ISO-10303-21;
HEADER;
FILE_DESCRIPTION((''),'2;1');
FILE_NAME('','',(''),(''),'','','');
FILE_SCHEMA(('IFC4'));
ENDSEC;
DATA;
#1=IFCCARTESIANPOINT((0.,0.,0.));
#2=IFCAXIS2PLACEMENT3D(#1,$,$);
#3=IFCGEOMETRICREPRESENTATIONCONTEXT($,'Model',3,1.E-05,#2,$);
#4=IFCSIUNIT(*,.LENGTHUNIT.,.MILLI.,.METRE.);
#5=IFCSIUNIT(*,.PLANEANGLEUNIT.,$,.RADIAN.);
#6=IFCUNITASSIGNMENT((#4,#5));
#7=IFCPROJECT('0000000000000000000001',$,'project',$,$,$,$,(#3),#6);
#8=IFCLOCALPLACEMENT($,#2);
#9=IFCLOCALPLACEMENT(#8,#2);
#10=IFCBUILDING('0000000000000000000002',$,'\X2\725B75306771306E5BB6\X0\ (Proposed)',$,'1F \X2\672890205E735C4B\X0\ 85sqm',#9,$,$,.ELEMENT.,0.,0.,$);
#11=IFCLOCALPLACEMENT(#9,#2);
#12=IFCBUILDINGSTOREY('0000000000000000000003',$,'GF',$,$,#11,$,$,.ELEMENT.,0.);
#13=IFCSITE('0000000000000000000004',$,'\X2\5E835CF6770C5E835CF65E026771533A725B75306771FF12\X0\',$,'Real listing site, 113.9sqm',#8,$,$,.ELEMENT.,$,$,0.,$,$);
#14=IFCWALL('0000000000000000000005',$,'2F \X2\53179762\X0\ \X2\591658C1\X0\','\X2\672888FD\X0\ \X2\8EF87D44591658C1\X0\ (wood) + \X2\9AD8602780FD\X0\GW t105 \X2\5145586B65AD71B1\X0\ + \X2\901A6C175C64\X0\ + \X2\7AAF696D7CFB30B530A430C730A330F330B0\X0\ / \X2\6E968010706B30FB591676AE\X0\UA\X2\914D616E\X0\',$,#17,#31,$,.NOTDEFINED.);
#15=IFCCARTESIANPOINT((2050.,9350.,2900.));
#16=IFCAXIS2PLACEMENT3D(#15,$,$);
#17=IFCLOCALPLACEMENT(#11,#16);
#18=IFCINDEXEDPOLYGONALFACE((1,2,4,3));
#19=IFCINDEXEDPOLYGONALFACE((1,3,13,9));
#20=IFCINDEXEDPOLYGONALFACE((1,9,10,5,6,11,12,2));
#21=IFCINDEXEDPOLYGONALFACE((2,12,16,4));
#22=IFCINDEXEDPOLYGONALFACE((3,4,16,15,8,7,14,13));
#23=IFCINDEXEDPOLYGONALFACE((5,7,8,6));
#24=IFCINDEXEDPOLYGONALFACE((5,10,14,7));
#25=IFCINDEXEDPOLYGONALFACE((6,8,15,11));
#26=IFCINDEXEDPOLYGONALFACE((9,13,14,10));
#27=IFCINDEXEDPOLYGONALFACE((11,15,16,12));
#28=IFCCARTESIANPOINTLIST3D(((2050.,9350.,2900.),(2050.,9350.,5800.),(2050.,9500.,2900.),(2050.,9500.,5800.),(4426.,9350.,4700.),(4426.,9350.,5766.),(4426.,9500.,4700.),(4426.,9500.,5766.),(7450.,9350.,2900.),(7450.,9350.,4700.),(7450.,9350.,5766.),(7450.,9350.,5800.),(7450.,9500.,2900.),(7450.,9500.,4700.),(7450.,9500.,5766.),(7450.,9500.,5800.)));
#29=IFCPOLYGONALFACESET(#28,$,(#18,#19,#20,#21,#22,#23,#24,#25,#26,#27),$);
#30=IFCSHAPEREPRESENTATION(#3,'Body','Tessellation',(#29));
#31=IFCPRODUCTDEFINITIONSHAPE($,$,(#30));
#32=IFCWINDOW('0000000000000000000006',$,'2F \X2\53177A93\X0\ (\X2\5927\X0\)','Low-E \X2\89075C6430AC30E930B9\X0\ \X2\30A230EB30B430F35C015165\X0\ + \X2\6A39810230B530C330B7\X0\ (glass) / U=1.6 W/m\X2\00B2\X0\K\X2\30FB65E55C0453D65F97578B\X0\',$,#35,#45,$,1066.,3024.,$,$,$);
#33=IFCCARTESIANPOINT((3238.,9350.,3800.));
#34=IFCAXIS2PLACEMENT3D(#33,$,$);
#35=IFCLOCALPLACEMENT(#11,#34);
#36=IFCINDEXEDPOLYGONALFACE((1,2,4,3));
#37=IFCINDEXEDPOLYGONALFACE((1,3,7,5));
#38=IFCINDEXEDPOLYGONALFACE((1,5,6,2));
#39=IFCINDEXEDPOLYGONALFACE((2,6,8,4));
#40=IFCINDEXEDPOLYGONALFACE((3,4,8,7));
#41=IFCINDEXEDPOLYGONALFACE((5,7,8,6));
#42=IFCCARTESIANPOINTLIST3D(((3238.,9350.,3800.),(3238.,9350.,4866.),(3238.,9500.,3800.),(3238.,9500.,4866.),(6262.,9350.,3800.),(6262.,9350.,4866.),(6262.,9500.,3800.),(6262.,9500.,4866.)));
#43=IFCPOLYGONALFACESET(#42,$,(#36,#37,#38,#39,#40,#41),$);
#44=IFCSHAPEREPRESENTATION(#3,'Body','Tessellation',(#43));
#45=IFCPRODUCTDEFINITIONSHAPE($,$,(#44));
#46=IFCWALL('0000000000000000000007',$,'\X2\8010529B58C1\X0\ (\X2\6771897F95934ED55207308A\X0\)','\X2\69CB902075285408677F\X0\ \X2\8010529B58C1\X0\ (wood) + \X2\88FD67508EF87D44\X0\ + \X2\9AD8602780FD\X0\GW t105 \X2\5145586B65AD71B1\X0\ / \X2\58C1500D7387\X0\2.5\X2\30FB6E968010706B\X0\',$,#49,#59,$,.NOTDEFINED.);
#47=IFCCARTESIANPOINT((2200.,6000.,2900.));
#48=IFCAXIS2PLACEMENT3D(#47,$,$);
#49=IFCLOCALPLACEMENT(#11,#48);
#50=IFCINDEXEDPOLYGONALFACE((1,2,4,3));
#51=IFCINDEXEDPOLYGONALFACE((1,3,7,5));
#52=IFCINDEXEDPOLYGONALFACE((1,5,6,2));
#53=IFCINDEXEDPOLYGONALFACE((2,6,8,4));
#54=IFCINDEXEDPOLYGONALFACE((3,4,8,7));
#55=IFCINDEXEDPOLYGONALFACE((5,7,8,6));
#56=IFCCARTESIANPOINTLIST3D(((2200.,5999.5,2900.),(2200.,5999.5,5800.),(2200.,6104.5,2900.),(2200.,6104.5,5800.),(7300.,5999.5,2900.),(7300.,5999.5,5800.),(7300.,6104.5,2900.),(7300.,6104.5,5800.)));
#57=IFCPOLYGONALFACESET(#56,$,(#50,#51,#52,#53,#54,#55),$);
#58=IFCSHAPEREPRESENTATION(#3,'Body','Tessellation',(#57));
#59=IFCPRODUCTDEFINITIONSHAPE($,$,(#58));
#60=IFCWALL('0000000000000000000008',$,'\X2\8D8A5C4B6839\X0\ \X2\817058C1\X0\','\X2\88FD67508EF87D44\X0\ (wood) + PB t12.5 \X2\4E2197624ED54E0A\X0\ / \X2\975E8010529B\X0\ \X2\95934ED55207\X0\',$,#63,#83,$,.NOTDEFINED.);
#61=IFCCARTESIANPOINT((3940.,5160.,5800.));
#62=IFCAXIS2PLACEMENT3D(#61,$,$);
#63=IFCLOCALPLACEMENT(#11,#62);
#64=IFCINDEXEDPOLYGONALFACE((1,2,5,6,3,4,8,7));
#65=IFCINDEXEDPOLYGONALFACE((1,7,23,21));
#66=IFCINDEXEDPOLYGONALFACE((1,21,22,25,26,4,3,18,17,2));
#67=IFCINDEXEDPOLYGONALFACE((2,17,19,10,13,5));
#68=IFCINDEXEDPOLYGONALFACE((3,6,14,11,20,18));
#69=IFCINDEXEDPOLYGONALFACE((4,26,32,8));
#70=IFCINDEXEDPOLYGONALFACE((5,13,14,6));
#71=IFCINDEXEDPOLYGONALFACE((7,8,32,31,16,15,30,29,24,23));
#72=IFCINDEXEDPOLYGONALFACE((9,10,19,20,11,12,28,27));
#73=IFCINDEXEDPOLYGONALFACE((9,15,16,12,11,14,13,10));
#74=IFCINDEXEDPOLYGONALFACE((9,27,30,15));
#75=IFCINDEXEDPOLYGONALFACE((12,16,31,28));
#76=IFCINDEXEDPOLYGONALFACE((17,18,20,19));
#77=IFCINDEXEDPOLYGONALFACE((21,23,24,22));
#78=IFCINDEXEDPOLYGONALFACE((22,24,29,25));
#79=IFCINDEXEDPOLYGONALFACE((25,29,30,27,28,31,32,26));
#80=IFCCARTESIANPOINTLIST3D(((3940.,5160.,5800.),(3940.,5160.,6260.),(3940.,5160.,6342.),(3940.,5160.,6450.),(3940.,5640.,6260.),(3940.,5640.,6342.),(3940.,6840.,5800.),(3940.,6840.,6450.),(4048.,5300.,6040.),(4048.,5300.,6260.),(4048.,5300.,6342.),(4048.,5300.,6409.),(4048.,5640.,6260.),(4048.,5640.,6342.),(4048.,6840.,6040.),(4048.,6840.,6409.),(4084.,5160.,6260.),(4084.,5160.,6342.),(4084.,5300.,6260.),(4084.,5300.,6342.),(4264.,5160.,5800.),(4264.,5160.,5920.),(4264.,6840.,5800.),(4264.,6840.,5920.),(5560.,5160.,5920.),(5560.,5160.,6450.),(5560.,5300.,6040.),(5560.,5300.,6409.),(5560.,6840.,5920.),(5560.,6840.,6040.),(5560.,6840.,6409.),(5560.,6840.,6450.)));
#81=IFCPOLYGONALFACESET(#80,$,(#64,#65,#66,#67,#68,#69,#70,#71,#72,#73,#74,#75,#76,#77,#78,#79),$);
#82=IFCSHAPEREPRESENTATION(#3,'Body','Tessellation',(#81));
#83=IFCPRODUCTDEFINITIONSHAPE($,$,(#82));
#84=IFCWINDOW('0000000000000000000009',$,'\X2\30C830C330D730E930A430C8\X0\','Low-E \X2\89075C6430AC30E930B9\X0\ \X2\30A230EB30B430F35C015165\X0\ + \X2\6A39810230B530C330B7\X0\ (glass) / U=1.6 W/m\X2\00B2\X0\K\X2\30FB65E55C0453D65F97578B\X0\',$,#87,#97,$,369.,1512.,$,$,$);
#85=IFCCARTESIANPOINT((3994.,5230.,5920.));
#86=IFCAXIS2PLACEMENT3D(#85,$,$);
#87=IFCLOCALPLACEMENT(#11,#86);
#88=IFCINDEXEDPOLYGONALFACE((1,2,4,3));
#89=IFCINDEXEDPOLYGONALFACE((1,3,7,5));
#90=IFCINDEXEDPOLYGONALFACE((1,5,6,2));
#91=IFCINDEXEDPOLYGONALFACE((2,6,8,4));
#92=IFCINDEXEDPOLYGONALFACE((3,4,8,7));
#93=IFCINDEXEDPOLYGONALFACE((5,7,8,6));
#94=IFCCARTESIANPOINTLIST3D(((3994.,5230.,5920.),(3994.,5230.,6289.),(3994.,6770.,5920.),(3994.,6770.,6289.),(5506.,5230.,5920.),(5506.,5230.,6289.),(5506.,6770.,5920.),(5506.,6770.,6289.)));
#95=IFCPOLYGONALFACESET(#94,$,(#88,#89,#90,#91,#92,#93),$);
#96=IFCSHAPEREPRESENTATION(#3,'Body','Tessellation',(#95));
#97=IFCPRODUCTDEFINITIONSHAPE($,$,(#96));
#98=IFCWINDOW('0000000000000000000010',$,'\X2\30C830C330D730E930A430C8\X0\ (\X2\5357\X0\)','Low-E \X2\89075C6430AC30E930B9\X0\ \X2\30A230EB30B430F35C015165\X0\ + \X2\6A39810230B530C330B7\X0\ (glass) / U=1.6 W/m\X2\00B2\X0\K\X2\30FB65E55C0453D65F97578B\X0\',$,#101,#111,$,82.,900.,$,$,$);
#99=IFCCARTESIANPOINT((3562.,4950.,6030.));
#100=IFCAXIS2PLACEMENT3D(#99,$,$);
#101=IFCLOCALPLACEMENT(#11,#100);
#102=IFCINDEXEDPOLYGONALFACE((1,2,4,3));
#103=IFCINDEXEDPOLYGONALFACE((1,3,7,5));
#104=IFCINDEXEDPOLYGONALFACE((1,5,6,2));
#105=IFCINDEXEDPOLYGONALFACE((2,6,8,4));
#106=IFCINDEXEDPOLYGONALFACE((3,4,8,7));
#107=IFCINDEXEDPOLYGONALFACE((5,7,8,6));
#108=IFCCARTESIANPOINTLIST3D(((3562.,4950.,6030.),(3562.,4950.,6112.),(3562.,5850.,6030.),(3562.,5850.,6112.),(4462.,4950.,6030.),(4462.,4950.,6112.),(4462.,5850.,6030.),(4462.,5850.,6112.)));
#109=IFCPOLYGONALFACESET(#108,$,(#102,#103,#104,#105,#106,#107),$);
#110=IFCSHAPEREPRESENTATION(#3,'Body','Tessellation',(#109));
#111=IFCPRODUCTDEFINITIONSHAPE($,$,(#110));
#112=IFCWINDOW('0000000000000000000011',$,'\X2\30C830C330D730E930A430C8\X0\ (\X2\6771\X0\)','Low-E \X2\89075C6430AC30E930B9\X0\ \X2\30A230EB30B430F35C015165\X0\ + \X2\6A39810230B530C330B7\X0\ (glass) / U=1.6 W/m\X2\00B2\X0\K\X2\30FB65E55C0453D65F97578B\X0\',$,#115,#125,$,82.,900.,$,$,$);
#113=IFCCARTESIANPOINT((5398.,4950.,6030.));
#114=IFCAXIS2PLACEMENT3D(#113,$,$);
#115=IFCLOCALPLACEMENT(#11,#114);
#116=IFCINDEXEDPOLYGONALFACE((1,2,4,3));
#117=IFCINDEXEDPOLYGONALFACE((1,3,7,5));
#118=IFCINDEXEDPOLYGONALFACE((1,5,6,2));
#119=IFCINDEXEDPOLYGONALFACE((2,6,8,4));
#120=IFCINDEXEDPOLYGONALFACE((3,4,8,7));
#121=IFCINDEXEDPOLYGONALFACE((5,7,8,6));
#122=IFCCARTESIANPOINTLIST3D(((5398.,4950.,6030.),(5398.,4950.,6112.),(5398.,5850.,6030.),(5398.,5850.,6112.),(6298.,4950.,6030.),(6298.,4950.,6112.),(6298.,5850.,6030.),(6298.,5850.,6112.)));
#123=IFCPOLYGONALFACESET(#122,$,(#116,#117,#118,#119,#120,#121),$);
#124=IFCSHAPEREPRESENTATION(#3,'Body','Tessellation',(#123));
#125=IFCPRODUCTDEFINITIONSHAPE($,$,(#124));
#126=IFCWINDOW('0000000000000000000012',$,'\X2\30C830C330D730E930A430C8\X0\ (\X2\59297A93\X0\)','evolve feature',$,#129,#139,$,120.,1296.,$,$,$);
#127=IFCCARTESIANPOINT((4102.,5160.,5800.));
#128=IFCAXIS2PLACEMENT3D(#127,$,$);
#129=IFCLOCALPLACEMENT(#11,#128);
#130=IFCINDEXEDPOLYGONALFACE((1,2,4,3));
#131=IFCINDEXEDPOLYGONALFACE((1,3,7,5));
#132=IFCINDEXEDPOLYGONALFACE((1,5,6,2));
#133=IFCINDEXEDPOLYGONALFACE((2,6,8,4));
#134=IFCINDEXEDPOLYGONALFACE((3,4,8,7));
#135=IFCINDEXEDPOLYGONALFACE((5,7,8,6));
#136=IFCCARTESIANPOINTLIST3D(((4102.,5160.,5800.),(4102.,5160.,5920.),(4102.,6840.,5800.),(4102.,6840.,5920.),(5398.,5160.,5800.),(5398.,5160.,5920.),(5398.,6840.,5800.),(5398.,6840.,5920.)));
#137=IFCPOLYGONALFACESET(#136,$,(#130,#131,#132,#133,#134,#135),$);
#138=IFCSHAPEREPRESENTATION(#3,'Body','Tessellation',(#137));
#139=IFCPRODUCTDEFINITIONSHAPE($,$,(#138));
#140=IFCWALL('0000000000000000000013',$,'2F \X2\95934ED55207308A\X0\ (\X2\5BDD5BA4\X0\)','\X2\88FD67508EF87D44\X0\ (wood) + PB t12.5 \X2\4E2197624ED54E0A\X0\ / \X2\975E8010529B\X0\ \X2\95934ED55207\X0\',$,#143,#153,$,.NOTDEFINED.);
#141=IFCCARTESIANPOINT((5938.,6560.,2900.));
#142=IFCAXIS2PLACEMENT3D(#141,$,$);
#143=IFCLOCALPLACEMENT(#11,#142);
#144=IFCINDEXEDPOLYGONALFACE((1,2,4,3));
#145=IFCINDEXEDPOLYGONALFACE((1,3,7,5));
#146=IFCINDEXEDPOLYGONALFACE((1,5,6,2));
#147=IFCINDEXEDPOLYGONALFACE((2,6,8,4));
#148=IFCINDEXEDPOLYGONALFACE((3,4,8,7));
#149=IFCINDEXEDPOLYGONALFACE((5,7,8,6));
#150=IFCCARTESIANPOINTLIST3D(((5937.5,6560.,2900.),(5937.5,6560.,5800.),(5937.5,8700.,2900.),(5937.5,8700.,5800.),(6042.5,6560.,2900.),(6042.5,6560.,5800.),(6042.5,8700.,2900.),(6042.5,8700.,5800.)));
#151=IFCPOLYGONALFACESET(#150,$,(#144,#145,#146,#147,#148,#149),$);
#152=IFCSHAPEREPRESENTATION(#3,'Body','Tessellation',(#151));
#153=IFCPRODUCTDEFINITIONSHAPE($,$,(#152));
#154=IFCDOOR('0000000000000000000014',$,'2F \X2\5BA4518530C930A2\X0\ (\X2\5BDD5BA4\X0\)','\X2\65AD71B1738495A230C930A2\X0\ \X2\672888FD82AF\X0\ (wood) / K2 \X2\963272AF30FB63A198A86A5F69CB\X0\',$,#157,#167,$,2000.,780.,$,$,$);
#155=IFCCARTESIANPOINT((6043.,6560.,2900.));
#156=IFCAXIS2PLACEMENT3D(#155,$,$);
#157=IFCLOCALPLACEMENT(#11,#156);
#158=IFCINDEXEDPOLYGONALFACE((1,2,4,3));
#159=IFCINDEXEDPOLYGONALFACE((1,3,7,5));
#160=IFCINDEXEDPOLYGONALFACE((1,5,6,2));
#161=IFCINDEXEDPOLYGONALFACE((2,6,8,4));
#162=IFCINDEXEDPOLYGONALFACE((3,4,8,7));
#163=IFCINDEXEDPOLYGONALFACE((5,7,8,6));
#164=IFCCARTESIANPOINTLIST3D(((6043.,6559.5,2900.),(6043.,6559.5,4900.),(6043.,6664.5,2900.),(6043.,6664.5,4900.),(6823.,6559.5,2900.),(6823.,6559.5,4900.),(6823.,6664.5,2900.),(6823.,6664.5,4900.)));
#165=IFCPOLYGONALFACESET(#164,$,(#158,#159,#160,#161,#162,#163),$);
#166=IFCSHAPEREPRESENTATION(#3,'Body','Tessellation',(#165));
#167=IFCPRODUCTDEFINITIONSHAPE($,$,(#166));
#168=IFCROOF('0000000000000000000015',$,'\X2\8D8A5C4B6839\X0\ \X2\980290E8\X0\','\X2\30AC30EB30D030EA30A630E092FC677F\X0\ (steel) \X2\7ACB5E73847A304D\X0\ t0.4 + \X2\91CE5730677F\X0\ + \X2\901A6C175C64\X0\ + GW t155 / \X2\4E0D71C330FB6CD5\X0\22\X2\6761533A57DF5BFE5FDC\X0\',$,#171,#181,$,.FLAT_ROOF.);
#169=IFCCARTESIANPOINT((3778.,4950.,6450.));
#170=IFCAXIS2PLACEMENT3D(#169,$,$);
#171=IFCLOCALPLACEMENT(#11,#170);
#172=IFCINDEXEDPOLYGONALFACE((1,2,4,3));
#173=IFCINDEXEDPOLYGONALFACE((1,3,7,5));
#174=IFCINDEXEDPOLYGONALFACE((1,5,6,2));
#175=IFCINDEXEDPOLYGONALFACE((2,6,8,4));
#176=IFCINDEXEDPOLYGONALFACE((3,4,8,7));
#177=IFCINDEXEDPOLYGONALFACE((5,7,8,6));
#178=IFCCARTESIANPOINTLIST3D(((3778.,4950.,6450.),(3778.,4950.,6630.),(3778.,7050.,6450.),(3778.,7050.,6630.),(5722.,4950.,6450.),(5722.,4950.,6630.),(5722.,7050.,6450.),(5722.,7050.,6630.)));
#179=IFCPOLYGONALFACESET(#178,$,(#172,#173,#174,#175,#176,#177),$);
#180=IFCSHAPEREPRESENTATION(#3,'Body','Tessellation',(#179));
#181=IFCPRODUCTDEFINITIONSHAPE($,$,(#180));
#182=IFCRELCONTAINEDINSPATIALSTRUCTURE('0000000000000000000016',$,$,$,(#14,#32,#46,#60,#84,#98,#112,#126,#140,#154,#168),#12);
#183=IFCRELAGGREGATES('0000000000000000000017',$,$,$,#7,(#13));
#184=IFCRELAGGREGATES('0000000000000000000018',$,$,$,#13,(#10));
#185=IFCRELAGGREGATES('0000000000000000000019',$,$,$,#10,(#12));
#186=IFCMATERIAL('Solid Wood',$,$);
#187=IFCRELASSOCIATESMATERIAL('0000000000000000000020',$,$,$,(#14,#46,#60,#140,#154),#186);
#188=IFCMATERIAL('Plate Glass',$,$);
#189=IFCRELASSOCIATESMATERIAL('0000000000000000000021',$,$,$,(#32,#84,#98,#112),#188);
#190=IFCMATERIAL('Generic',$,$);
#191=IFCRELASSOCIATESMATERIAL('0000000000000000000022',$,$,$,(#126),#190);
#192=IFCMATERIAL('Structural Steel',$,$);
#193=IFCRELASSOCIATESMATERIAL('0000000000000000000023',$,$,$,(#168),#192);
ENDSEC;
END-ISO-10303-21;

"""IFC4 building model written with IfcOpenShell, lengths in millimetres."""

from ifc_helpers import new_model, si_unit, frame, frame_2d, origin, place, context, project, spatial, rectangle, extrude, material, element, fill, save


model = new_model("IFC4")

# Units and contexts
model_context = context("Model", 3, precision=1e-05, world=origin())
ifc_project = project(units=[si_unit("LENGTHUNIT", "METRE", prefix="MILLI"), si_unit("PLANEANGLEUNIT", "RADIAN")], contexts=[model_context])

# Site, building, storey
site_placement = place(None, origin())
site = spatial("IfcSite", under=ifc_project, at=site_placement, Name="広島県広島市東区牛田東２", ObjectType="Real listing site, 113.9sqm", CompositionType="ELEMENT", RefElevation=0.0)
building_placement = place(site_placement, origin())
building = spatial("IfcBuilding", under=site, at=building_placement, Name="牛田東の家 (Proposed)", ObjectType="1F 木造平屋 85sqm", CompositionType="ELEMENT", ElevationOfRefHeight=0.0, ElevationOfTerrain=0.0)
storey_placement = place(building_placement, origin())
storey = spatial("IfcBuildingStorey", under=building, at=storey_placement, Name="GF", CompositionType="ELEMENT", Elevation=0.0)

# Wall, opening, window
ifc_material_1 = material(Name="Solid Wood")
wall_1_placement = place(storey_placement, frame((2050.0, 9350.0, 2900.0)))
wall_1 = element("IfcWall", 1, at=wall_1_placement, inside=storey, material=ifc_material_1, Name="2F 北面 外壁", Description="木製 軸組外壁 (wood) + 高性能GW t105 充填断熱 + 通気層 + 窯業系サイディング / 準耐火・外皮UA配慮", PredefinedType="NOTDEFINED", context=model_context, shape_type="SweptSolid", body=[
    extrude(rectangle(XDim=5400.0, YDim=150.0, at=frame_2d((2700.0, 75.0))), frame((2050.0, 9350.0, 2900.0)), (0.0, 0.0, 1.0), 2900.0),
])
opening_1_placement = place(storey_placement, frame((3238.0, 9350.0, 3800.0)))
opening_1 = element("IfcOpeningElement", 2, at=opening_1_placement, cuts=wall_1, PredefinedType="NOTDEFINED", context=model_context, shape_type="SweptSolid", body=[
    extrude(rectangle(XDim=3024.0, YDim=150.0, at=frame_2d((1512.0, 75.0))), frame((3238.0, 9350.0, 3800.0)), (0.0, 0.0, 1.0), 1066.0),
])
ifc_material_2 = material(Name="Plate Glass")
window_1_placement = place(storey_placement, frame((3238.0, 9350.0, 3800.0)))
window_1 = element("IfcWindow", 3, at=window_1_placement, inside=storey, material=ifc_material_2, Name="2F 北窓 (大)", Description="Low-E 複層ガラス アルゴン封入 + 樹脂サッシ (glass) / U=1.6 W/m²K・日射取得型", OverallHeight=1066.0, OverallWidth=3024.0, context=model_context, shape_type="SweptSolid", body=[
    extrude(rectangle(XDim=3024.0, YDim=150.0, at=frame_2d((1512.0, 75.0))), frame((3238.0, 9350.0, 3800.0)), (0.0, 0.0, 1.0), 1066.0),
])
fill(opening_1, window_1)

# Wall
wall_2_placement = place(storey_placement, frame((2200.0, 6000.0, 2900.0)))
element("IfcWall", 4, at=wall_2_placement, inside=storey, material=ifc_material_1, Name="耐力壁 (東西間仕切り)", Description="構造用合板 耐力壁 (wood) + 製材軸組 + 高性能GW t105 充填断熱 / 壁倍率2.5・準耐火", PredefinedType="NOTDEFINED", context=model_context, shape_type="SweptSolid", body=[
    extrude(rectangle(XDim=5100.0, YDim=105.0, at=frame_2d((2550.0, 52.0))), frame((2200.0, 6000.0, 2900.0)), (0.0, 0.0, 1.0), 2900.0),
])

# Wall, openings, windows
wall_3_placement = place(storey_placement, frame((3940.0, 5160.0, 5800.0)))
wall_3 = element("IfcWall", 5, at=wall_3_placement, inside=storey, material=ifc_material_1, Name="越屋根 腰壁", Description="製材軸組 (wood) + PB t12.5 両面仕上 / 非耐力 間仕切", PredefinedType="NOTDEFINED", context=model_context, shape_type="SweptSolid", body=[
    extrude(rectangle(XDim=1620.0, YDim=1680.0, at=frame_2d((810.0, 840.0))), frame((3940.0, 5160.0, 5800.0)), (0.0, 0.0, 1.0), 650.0),
])
opening_2_placement = place(storey_placement, frame((3994.0, 5230.0, 5920.0)))
opening_2 = element("IfcOpeningElement", 6, at=opening_2_placement, cuts=wall_3, PredefinedType="NOTDEFINED", context=model_context, shape_type="SweptSolid", body=[
    extrude(rectangle(XDim=1512.0, YDim=1540.0, at=frame_2d((756.0, 770.0))), frame((3994.0, 5230.0, 5920.0)), (0.0, 0.0, 1.0), 369.0),
])
opening_3_placement = place(storey_placement, frame((3562.0, 4950.0, 6030.0)))
opening_3 = element("IfcOpeningElement", 7, at=opening_3_placement, cuts=wall_3, PredefinedType="NOTDEFINED", context=model_context, shape_type="SweptSolid", body=[
    extrude(rectangle(XDim=900.0, YDim=900.0, at=frame_2d((450.0, 450.0))), frame((3562.0, 4950.0, 6030.0)), (0.0, 0.0, 1.0), 82.0),
])
opening_4_placement = place(storey_placement, frame((5398.0, 4950.0, 6030.0)))
opening_4 = element("IfcOpeningElement", 8, at=opening_4_placement, cuts=wall_3, PredefinedType="NOTDEFINED", context=model_context, shape_type="SweptSolid", body=[
    extrude(rectangle(XDim=900.0, YDim=900.0, at=frame_2d((450.0, 450.0))), frame((5398.0, 4950.0, 6030.0)), (0.0, 0.0, 1.0), 82.0),
])
opening_5_placement = place(storey_placement, frame((4102.0, 5160.0, 5800.0)))
opening_5 = element("IfcOpeningElement", 9, at=opening_5_placement, cuts=wall_3, PredefinedType="NOTDEFINED", context=model_context, shape_type="SweptSolid", body=[
    extrude(rectangle(XDim=1296.0, YDim=1680.0, at=frame_2d((648.0, 840.0))), frame((4102.0, 5160.0, 5800.0)), (0.0, 0.0, 1.0), 120.0),
])
window_2_placement = place(storey_placement, frame((3994.0, 5230.0, 5920.0)))
window_2 = element("IfcWindow", 10, at=window_2_placement, inside=storey, material=ifc_material_2, Name="トップライト", Description="Low-E 複層ガラス アルゴン封入 + 樹脂サッシ (glass) / U=1.6 W/m²K・日射取得型", OverallHeight=369.0, OverallWidth=1512.0, context=model_context, shape_type="SweptSolid", body=[
    extrude(rectangle(XDim=1512.0, YDim=1540.0, at=frame_2d((756.0, 770.0))), frame((3994.0, 5230.0, 5920.0)), (0.0, 0.0, 1.0), 369.0),
])
fill(opening_2, window_2)
window_3_placement = place(storey_placement, frame((3562.0, 4950.0, 6030.0)))
window_3 = element("IfcWindow", 11, at=window_3_placement, inside=storey, material=ifc_material_2, Name="トップライト (南)", Description="Low-E 複層ガラス アルゴン封入 + 樹脂サッシ (glass) / U=1.6 W/m²K・日射取得型", OverallHeight=82.0, OverallWidth=900.0, context=model_context, shape_type="SweptSolid", body=[
    extrude(rectangle(XDim=900.0, YDim=900.0, at=frame_2d((450.0, 450.0))), frame((3562.0, 4950.0, 6030.0)), (0.0, 0.0, 1.0), 82.0),
])
fill(opening_3, window_3)
window_4_placement = place(storey_placement, frame((5398.0, 4950.0, 6030.0)))
window_4 = element("IfcWindow", 12, at=window_4_placement, inside=storey, material=ifc_material_2, Name="トップライト (東)", Description="Low-E 複層ガラス アルゴン封入 + 樹脂サッシ (glass) / U=1.6 W/m²K・日射取得型", OverallHeight=82.0, OverallWidth=900.0, context=model_context, shape_type="SweptSolid", body=[
    extrude(rectangle(XDim=900.0, YDim=900.0, at=frame_2d((450.0, 450.0))), frame((5398.0, 4950.0, 6030.0)), (0.0, 0.0, 1.0), 82.0),
])
fill(opening_4, window_4)
ifc_material_3 = material(Name="Generic")
window_5_placement = place(storey_placement, frame((4102.0, 5160.0, 5800.0)))
window_5 = element("IfcWindow", 13, at=window_5_placement, inside=storey, material=ifc_material_3, Name="トップライト (天窓)", Description="evolve feature", OverallHeight=120.0, OverallWidth=1296.0, context=model_context, shape_type="SweptSolid", body=[
    extrude(rectangle(XDim=1296.0, YDim=1680.0, at=frame_2d((648.0, 840.0))), frame((4102.0, 5160.0, 5800.0)), (0.0, 0.0, 1.0), 120.0),
])
fill(opening_5, window_5)

# Wall
wall_4_placement = place(storey_placement, frame((5938.0, 6560.0, 2900.0)))
element("IfcWall", 14, at=wall_4_placement, inside=storey, material=ifc_material_1, Name="2F 間仕切り (寝室)", Description="製材軸組 (wood) + PB t12.5 両面仕上 / 非耐力 間仕切", PredefinedType="NOTDEFINED", context=model_context, shape_type="SweptSolid", body=[
    extrude(rectangle(XDim=105.0, YDim=2140.0, at=frame_2d((52.0, 1070.0))), frame((5938.0, 6560.0, 2900.0)), (0.0, 0.0, 1.0), 2900.0),
])

# Door
door_placement = place(storey_placement, frame((6043.0, 6560.0, 2900.0)))
element("IfcDoor", 15, at=door_placement, inside=storey, material=ifc_material_1, Name="2F 室内ドア (寝室)", Description="断熱玄関ドア 木製芯 (wood) / K2 防犯・採風機構", OverallHeight=2000.0, OverallWidth=780.0, context=model_context, shape_type="SweptSolid", body=[
    extrude(rectangle(XDim=780.0, YDim=105.0, at=frame_2d((390.0, 52.0))), frame((6043.0, 6560.0, 2900.0)), (0.0, 0.0, 1.0), 2000.0),
])

# Roof
ifc_material_4 = material(Name="Structural Steel")
roof_placement = place(storey_placement, frame((3778.0, 4950.0, 6450.0)))
element("IfcRoof", 16, at=roof_placement, inside=storey, material=ifc_material_4, Name="越屋根 頂部", Description="ガルバリウム鋼板 (steel) 立平葺き t0.4 + 野地板 + 通気層 + GW t155 / 不燃・法22条区域対応", PredefinedType="FLAT_ROOF", context=model_context, shape_type="SweptSolid", body=[
    extrude(rectangle(XDim=1944.0, YDim=2100.0, at=frame_2d((972.0, 1050.0))), frame((3778.0, 4950.0, 6450.0)), (0.0, 0.0, 1.0), 180.0),
])

save(model, "model.ifc")
